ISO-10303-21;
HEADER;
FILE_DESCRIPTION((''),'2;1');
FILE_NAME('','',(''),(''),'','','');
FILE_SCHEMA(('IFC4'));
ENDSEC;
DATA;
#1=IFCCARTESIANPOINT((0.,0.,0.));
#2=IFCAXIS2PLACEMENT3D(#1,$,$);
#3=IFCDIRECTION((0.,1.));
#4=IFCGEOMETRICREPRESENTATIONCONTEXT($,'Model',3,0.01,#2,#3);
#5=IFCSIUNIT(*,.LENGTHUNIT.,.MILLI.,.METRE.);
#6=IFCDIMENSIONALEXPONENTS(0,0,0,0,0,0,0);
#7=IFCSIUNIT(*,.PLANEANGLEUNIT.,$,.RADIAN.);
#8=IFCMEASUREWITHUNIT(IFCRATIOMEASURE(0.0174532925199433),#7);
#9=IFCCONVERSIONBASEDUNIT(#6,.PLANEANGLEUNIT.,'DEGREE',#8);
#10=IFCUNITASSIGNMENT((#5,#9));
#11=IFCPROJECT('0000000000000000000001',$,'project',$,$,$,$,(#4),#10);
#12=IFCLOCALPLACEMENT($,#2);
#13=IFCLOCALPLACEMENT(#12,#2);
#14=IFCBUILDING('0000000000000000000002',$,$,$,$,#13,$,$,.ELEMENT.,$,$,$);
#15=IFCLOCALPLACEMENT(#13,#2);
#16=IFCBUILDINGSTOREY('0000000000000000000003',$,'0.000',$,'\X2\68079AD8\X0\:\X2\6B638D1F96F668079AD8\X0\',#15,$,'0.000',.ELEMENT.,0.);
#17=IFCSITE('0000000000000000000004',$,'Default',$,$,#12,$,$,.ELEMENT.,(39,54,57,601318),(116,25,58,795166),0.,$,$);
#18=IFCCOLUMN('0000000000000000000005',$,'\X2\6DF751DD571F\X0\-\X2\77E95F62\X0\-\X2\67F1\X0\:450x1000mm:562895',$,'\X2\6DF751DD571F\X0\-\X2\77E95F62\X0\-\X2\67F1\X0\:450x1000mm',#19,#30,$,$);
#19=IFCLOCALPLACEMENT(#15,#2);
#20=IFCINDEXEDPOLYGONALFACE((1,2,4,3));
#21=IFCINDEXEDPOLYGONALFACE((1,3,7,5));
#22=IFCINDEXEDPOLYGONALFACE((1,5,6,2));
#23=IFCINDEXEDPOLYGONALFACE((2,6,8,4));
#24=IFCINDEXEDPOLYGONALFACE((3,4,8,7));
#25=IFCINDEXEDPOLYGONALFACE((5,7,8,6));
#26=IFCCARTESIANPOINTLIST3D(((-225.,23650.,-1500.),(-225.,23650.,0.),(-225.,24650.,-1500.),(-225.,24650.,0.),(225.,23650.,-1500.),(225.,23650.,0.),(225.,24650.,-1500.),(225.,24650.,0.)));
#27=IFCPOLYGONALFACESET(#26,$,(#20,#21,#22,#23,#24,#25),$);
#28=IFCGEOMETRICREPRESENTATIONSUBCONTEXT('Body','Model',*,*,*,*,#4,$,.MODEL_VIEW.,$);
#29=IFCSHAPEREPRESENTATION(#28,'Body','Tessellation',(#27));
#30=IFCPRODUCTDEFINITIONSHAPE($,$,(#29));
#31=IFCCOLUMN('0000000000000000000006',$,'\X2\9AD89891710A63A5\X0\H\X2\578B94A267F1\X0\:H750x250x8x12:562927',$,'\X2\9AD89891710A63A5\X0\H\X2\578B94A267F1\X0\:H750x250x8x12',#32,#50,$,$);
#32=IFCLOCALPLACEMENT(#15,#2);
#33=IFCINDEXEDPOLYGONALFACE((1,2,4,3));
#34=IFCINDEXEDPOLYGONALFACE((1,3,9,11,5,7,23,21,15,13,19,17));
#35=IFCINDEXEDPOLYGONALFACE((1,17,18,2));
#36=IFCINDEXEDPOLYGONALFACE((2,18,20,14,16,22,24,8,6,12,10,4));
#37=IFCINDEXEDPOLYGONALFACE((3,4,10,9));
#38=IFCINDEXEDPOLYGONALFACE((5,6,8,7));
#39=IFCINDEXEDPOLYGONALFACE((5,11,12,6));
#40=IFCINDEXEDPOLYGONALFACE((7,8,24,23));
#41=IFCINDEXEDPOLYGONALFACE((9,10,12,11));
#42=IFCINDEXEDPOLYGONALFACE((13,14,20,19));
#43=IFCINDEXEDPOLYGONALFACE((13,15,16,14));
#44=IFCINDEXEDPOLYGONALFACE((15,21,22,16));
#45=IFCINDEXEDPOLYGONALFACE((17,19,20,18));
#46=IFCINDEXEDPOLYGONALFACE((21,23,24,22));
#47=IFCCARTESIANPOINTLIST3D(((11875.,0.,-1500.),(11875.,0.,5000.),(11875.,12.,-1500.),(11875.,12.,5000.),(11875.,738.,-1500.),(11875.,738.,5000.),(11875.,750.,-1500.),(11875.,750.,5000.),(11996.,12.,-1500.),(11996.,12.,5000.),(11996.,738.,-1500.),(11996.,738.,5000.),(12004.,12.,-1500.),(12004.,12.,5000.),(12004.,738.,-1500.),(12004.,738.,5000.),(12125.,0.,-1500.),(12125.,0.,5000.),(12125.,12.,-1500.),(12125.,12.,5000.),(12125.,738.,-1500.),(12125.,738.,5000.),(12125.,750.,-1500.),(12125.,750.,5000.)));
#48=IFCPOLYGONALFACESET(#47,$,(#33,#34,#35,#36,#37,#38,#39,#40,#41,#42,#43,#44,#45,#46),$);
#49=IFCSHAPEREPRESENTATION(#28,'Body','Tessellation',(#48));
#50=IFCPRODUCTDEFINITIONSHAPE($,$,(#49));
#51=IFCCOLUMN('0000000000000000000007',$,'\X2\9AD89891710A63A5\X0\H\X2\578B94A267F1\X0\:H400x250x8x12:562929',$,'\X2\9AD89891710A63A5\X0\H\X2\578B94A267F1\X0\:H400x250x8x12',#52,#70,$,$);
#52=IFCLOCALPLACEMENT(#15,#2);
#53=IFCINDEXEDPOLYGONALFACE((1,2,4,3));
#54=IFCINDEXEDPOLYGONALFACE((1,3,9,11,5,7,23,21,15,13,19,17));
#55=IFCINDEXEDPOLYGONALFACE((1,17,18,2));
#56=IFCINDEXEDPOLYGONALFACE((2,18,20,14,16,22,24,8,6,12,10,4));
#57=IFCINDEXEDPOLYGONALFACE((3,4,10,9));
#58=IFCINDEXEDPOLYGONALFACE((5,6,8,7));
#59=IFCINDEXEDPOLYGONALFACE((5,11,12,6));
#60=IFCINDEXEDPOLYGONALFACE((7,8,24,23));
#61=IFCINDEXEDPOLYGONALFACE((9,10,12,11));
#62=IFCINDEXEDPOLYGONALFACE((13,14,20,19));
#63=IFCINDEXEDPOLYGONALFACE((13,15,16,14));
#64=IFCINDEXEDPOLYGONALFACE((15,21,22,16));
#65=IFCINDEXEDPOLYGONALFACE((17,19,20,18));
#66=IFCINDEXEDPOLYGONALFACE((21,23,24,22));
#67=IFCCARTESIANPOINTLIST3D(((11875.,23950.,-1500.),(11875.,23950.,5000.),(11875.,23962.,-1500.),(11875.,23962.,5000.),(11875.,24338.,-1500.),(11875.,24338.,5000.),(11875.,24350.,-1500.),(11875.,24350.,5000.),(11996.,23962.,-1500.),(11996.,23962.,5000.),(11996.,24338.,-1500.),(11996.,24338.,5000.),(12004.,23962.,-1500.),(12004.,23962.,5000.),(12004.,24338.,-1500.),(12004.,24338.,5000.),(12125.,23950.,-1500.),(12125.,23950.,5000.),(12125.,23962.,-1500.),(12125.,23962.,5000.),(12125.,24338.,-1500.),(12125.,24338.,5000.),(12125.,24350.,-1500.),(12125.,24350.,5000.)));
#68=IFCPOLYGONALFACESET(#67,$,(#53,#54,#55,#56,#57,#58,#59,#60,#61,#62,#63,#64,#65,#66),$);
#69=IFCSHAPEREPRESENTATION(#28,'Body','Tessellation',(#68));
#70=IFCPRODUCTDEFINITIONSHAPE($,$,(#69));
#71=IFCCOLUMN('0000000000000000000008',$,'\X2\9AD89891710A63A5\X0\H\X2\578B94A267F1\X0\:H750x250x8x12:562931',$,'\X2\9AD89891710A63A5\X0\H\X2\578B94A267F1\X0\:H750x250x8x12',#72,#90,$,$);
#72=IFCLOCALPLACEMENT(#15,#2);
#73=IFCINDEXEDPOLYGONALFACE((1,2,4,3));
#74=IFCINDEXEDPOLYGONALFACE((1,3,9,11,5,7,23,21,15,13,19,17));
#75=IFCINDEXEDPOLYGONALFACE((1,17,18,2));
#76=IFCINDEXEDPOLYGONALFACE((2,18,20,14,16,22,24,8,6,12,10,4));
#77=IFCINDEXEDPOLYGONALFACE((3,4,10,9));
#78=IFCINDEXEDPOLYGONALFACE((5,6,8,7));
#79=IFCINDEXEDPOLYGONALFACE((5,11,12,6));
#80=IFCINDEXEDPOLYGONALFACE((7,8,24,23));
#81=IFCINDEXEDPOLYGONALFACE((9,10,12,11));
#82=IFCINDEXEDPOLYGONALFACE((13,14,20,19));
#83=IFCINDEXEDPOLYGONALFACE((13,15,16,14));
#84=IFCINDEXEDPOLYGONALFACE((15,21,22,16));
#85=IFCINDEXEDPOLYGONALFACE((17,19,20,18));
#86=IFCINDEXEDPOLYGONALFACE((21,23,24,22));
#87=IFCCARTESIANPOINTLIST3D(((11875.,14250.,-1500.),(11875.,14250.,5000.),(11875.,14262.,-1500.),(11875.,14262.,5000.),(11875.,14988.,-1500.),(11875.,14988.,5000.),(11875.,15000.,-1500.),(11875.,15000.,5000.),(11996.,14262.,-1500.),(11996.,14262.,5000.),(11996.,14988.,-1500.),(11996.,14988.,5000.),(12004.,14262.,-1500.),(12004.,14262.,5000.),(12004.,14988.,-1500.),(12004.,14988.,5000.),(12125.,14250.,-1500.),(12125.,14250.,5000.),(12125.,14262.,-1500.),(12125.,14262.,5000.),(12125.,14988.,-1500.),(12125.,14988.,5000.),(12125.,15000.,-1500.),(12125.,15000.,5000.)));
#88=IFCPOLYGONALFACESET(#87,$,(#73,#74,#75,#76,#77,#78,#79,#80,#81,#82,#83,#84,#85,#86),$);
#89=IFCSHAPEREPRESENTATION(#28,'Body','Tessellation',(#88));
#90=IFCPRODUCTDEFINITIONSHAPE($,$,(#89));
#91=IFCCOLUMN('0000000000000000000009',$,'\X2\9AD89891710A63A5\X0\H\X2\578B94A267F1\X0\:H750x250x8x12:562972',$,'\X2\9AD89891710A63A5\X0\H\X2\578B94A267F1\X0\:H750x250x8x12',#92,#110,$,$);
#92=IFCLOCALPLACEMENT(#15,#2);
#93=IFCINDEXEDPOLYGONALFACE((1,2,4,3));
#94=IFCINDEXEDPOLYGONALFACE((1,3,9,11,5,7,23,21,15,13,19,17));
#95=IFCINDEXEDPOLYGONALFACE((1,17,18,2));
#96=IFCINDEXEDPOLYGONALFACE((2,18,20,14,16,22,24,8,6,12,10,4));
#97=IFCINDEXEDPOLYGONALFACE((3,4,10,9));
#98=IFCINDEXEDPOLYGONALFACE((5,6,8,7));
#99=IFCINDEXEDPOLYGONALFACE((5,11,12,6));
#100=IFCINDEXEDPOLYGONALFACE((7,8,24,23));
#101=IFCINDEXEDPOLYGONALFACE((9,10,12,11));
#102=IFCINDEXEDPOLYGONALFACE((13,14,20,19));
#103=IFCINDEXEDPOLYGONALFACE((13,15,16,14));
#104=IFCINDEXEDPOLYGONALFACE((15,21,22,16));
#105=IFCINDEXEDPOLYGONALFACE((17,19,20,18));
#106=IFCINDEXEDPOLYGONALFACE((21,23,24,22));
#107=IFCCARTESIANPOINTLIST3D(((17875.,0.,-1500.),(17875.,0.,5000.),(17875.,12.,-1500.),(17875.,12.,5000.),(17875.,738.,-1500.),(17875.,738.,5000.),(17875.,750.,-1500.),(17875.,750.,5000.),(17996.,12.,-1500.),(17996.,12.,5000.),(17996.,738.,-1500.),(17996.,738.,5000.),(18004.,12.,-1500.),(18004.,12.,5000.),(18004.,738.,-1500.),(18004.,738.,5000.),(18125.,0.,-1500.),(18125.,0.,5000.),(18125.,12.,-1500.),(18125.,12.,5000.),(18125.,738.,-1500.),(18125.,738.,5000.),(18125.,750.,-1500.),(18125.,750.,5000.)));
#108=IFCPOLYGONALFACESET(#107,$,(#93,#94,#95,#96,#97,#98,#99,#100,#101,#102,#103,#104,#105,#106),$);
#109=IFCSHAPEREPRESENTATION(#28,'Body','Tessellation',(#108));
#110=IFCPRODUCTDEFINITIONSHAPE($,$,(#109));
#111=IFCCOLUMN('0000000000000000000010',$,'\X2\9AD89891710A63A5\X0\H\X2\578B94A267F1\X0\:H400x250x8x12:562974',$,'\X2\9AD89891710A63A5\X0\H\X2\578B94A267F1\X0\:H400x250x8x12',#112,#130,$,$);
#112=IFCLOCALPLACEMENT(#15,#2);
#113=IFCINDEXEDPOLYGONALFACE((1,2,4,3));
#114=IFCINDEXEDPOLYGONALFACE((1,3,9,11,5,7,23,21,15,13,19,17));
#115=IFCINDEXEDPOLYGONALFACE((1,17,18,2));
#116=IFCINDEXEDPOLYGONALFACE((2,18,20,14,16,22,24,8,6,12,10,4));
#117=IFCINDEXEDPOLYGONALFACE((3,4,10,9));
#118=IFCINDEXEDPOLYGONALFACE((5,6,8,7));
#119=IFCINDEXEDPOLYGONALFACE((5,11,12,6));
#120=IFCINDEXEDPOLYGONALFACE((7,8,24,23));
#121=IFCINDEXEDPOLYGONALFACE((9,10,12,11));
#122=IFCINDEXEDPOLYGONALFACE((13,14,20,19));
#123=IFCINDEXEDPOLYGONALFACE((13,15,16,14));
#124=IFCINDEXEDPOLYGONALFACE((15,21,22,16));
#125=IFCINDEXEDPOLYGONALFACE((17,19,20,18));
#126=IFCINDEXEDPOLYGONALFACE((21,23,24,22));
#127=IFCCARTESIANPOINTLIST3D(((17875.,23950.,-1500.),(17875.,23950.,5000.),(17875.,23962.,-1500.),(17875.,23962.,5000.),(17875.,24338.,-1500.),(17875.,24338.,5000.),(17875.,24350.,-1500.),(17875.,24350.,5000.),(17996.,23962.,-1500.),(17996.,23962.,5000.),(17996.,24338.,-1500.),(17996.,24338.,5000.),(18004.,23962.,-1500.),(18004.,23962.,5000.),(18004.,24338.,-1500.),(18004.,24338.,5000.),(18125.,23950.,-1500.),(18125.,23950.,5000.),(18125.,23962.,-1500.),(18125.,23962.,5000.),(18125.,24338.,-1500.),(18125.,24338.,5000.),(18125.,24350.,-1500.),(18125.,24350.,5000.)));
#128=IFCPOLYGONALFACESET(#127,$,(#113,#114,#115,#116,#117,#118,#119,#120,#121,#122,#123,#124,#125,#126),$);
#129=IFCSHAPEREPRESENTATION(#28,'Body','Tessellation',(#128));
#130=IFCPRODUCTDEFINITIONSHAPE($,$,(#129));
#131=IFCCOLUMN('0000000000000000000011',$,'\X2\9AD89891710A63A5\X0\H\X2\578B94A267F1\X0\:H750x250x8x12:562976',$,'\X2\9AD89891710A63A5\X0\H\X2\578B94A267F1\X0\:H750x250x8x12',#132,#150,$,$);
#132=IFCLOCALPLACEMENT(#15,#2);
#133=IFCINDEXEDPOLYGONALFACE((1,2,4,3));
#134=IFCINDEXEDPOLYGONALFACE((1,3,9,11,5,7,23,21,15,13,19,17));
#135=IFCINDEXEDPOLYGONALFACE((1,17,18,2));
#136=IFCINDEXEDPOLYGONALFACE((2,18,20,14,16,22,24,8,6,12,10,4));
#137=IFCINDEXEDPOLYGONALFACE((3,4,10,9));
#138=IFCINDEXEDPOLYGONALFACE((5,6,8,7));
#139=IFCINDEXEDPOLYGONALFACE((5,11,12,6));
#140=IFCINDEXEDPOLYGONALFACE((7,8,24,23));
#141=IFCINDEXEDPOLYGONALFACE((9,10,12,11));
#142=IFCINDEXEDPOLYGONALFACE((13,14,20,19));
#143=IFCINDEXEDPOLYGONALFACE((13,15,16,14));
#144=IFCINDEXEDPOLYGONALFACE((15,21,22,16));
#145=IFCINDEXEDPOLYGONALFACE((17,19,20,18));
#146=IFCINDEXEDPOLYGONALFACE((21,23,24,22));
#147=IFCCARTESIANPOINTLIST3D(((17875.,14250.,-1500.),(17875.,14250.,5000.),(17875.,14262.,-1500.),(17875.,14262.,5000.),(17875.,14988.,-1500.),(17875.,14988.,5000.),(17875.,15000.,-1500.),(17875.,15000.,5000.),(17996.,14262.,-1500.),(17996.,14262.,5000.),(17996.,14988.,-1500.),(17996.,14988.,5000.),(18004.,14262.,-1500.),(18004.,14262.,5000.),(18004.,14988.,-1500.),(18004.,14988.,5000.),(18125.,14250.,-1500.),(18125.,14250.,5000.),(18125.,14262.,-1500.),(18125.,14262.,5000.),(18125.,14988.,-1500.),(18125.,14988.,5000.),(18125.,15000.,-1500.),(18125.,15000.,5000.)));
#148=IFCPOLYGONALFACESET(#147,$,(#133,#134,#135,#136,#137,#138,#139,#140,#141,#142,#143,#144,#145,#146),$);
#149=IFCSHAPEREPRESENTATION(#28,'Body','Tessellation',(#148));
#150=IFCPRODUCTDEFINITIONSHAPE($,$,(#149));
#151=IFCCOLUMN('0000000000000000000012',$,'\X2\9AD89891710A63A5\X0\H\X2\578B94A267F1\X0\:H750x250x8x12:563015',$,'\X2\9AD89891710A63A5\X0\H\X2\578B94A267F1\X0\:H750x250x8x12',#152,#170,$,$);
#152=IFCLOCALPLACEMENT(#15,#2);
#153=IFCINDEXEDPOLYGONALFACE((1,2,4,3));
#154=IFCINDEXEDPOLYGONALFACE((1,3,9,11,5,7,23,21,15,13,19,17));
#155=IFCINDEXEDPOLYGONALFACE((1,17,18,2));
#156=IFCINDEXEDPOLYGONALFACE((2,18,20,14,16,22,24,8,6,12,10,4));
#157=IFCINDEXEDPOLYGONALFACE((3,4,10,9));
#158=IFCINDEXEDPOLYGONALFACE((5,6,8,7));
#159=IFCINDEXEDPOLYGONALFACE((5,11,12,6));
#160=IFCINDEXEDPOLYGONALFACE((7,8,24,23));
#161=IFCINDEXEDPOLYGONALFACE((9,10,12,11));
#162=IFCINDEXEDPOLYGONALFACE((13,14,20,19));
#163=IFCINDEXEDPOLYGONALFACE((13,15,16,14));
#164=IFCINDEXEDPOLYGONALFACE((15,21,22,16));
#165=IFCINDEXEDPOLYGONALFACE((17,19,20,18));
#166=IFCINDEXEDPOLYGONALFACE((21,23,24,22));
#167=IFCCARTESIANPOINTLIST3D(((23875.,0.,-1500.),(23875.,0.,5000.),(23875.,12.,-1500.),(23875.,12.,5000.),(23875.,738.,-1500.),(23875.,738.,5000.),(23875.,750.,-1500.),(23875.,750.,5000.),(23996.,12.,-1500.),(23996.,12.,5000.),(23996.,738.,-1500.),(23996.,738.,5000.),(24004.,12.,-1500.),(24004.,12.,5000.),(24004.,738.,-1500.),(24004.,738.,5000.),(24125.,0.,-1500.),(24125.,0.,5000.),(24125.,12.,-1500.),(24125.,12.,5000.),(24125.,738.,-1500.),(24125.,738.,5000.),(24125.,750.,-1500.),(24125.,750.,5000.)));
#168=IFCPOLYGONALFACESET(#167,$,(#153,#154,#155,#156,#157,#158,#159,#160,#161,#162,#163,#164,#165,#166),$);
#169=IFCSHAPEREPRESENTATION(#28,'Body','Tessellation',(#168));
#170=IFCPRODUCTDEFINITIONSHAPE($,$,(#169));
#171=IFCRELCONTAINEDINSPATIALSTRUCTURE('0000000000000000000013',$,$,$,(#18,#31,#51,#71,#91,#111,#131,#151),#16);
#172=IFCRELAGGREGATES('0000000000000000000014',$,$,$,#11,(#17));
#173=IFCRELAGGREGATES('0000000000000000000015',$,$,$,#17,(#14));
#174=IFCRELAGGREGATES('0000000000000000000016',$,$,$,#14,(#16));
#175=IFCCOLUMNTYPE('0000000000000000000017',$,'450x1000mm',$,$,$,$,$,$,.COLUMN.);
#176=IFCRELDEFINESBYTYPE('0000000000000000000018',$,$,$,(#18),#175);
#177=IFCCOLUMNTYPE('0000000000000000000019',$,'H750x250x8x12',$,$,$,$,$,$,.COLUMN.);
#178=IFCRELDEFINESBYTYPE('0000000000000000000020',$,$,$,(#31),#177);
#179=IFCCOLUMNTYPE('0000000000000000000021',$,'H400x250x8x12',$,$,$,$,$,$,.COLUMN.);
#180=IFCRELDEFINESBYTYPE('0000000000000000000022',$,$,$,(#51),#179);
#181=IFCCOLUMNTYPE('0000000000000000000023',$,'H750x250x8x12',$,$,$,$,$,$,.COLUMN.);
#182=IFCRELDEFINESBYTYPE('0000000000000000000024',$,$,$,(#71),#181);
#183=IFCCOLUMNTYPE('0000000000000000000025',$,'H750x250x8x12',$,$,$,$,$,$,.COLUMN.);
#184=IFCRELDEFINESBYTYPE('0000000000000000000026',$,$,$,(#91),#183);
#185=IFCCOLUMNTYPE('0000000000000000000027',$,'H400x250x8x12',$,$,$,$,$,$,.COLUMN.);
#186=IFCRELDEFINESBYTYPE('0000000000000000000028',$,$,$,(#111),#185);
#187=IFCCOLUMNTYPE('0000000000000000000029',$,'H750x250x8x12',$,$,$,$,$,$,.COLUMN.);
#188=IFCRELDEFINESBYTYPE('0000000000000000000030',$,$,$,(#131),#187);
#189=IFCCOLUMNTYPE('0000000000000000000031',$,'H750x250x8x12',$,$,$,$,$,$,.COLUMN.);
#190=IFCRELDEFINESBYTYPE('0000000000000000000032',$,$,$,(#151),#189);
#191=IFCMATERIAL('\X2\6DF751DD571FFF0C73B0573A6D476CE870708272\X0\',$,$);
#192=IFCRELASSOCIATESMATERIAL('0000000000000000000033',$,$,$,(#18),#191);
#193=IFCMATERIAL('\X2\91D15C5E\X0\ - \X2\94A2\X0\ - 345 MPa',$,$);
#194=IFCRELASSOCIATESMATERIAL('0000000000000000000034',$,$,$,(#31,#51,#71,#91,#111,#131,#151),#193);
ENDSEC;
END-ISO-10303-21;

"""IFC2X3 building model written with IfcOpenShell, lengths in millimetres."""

from ifc_helpers import new_model, entity, si_unit, converted_unit, direction, frame, origin, origin_2d_with_axis, place, context, subcontext, project, spatial, polyline, rectangle, outline, extrude, source, transform, mapped, material, type_object, type_shapes, element, save


model = new_model("IFC2X3")

# Units and contexts
model_context = context("Model", 3, precision=0.01, world=origin(), true_north=direction((0.0, 1.0)))
body_context = subcontext(model_context, "Body", "Model", "MODEL_VIEW")
ifc_project = project(units=[si_unit("LENGTHUNIT", "METRE", prefix="MILLI"), converted_unit("PLANEANGLEUNIT", "DEGREE", entity("IfcRatioMeasure", 0.0174532925199433), si_unit("PLANEANGLEUNIT", "RADIAN"), dimensions=[0, 0, 0, 0, 0, 0, 0])], contexts=[model_context])

# Site, building, storey
site_placement = place(None, origin())
site = spatial("IfcSite", under=ifc_project, at=site_placement, Name="Default", CompositionType="ELEMENT", RefLatitude=(39, 54, 57, 601318), RefLongitude=(116, 25, 58, 795166), RefElevation=0.0)
building_placement = place(site_placement, origin())
building = spatial("IfcBuilding", under=site, at=building_placement, CompositionType="ELEMENT")
storey_placement = place(building_placement, origin())
storey = spatial("IfcBuildingStorey", under=building, at=storey_placement, Name="0.000", ObjectType="标高:正负零标高", LongName="0.000", CompositionType="ELEMENT", Elevation=0.0)

# Columns
ifc_material_1 = material(Name="混凝土，现场浇注灰色")
column_type_1 = type_object("IfcColumnType", Name="450x1000mm", PredefinedType="COLUMN")
shared_shape_1 = source(origin(), body_context, "Body", "SweptSolid", [
    extrude(rectangle(XDim=1000.0, YDim=450.0, at=origin_2d_with_axis()), frame((0.0, 24150.0, -1500.0), z_axis=(0.0, 0.0, 1.0), x_axis=(0.0, -1.0, 0.0)), (0.0, 0.0, 1.0), 1500.0),
])
type_shapes(column_type_1, [shared_shape_1])
column_1_placement = place(storey_placement, origin())
element("IfcColumn", 1, at=column_1_placement, inside=storey, type_object=column_type_1, material=ifc_material_1, Name="混凝土-矩形-柱:450x1000mm:562895", ObjectType="混凝土-矩形-柱:450x1000mm", context=body_context, shape_type="MappedRepresentation", body=[
    mapped(shared_shape_1, transform((0.0, 0.0, 0.0), scale=1.0)),
])
ifc_material_2 = material(Name="金属 - 钢 - 345 MPa")
column_type_2 = type_object("IfcColumnType", Name="H750x250x8x12", PredefinedType="COLUMN")
shared_shape_2 = source(origin(), body_context, "Body", "SweptSolid", [
    extrude(outline(polyline([(363.0, -125.0), (375.0, -125.0), (375.0, 125.0), (363.0, 125.0), (363.0, 4.0), (-363.0, 4.0), (-363.0, 125.0), (-375.0, 125.0), (-375.0, -125.0), (-363.0, -125.0), (-363.0, -4.0), (363.0, -4.0), (363.0, -125.0)])), frame((12000.0, 375.0, -1500.0), z_axis=(0.0, 0.0, 1.0), x_axis=(0.0, -1.0, 0.0)), (0.0, 0.0, 1.0), 6500.0),
])
type_shapes(column_type_2, [shared_shape_2])
column_2_placement = place(storey_placement, origin())
element("IfcColumn", 2, at=column_2_placement, inside=storey, type_object=column_type_2, material=ifc_material_2, Name="高频焊接H型钢柱:H750x250x8x12:562927", ObjectType="高频焊接H型钢柱:H750x250x8x12", context=body_context, shape_type="MappedRepresentation", body=[
    mapped(shared_shape_2, transform((0.0, 0.0, 0.0), scale=1.0)),
])
column_type_3 = type_object("IfcColumnType", Name="H400x250x8x12", PredefinedType="COLUMN")
shared_shape_3 = source(origin(), body_context, "Body", "SweptSolid", [
    extrude(outline(polyline([(188.0, -125.0), (200.0, -125.0), (200.0, 125.0), (188.0, 125.0), (188.0, 4.0), (-188.0, 4.0), (-188.0, 125.0), (-200.0, 125.0), (-200.0, -125.0), (-188.0, -125.0), (-188.0, -4.0), (188.0, -4.0), (188.0, -125.0)])), frame((12000.0, 24150.0, -1500.0), z_axis=(0.0, 0.0, 1.0), x_axis=(0.0, -1.0, 0.0)), (0.0, 0.0, 1.0), 6500.0),
])
type_shapes(column_type_3, [shared_shape_3])
column_3_placement = place(storey_placement, origin())
element("IfcColumn", 3, at=column_3_placement, inside=storey, type_object=column_type_3, material=ifc_material_2, Name="高频焊接H型钢柱:H400x250x8x12:562929", ObjectType="高频焊接H型钢柱:H400x250x8x12", context=body_context, shape_type="MappedRepresentation", body=[
    mapped(shared_shape_3, transform((0.0, 0.0, 0.0), scale=1.0)),
])
column_type_4 = type_object("IfcColumnType", Name="H750x250x8x12", PredefinedType="COLUMN")
shared_shape_4 = source(origin(), body_context, "Body", "SweptSolid", [
    extrude(outline(polyline([(363.0, -125.0), (375.0, -125.0), (375.0, 125.0), (363.0, 125.0), (363.0, 4.0), (-363.0, 4.0), (-363.0, 125.0), (-375.0, 125.0), (-375.0, -125.0), (-363.0, -125.0), (-363.0, -4.0), (363.0, -4.0), (363.0, -125.0)])), frame((12000.0, 14625.0, -1500.0), z_axis=(0.0, 0.0, 1.0), x_axis=(0.0, -1.0, 0.0)), (0.0, 0.0, 1.0), 6500.0),
])
type_shapes(column_type_4, [shared_shape_4])
column_4_placement = place(storey_placement, origin())
element("IfcColumn", 4, at=column_4_placement, inside=storey, type_object=column_type_4, material=ifc_material_2, Name="高频焊接H型钢柱:H750x250x8x12:562931", ObjectType="高频焊接H型钢柱:H750x250x8x12", context=body_context, shape_type="MappedRepresentation", body=[
    mapped(shared_shape_4, transform((0.0, 0.0, 0.0), scale=1.0)),
])
column_type_5 = type_object("IfcColumnType", Name="H750x250x8x12", PredefinedType="COLUMN")
shared_shape_5 = source(origin(), body_context, "Body", "SweptSolid", [
    extrude(outline(polyline([(363.0, -125.0), (375.0, -125.0), (375.0, 125.0), (363.0, 125.0), (363.0, 4.0), (-363.0, 4.0), (-363.0, 125.0), (-375.0, 125.0), (-375.0, -125.0), (-363.0, -125.0), (-363.0, -4.0), (363.0, -4.0), (363.0, -125.0)])), frame((18000.0, 375.0, -1500.0), z_axis=(0.0, 0.0, 1.0), x_axis=(0.0, -1.0, 0.0)), (0.0, 0.0, 1.0), 6500.0),
])
type_shapes(column_type_5, [shared_shape_5])
column_5_placement = place(storey_placement, origin())
element("IfcColumn", 5, at=column_5_placement, inside=storey, type_object=column_type_5, material=ifc_material_2, Name="高频焊接H型钢柱:H750x250x8x12:562972", ObjectType="高频焊接H型钢柱:H750x250x8x12", context=body_context, shape_type="MappedRepresentation", body=[
    mapped(shared_shape_5, transform((0.0, 0.0, 0.0), scale=1.0)),
])
column_type_6 = type_object("IfcColumnType", Name="H400x250x8x12", PredefinedType="COLUMN")
shared_shape_6 = source(origin(), body_context, "Body", "SweptSolid", [
    extrude(outline(polyline([(188.0, -125.0), (200.0, -125.0), (200.0, 125.0), (188.0, 125.0), (188.0, 4.0), (-188.0, 4.0), (-188.0, 125.0), (-200.0, 125.0), (-200.0, -125.0), (-188.0, -125.0), (-188.0, -4.0), (188.0, -4.0), (188.0, -125.0)])), frame((18000.0, 24150.0, -1500.0), z_axis=(0.0, 0.0, 1.0), x_axis=(0.0, -1.0, 0.0)), (0.0, 0.0, 1.0), 6500.0),
])
type_shapes(column_type_6, [shared_shape_6])
column_6_placement = place(storey_placement, origin())
element("IfcColumn", 6, at=column_6_placement, inside=storey, type_object=column_type_6, material=ifc_material_2, Name="高频焊接H型钢柱:H400x250x8x12:562974", ObjectType="高频焊接H型钢柱:H400x250x8x12", context=body_context, shape_type="MappedRepresentation", body=[
    mapped(shared_shape_6, transform((0.0, 0.0, 0.0), scale=1.0)),
])
column_type_7 = type_object("IfcColumnType", Name="H750x250x8x12", PredefinedType="COLUMN")
shared_shape_7 = source(origin(), body_context, "Body", "SweptSolid", [
    extrude(outline(polyline([(363.0, -125.0), (375.0, -125.0), (375.0, 125.0), (363.0, 125.0), (363.0, 4.0), (-363.0, 4.0), (-363.0, 125.0), (-375.0, 125.0), (-375.0, -125.0), (-363.0, -125.0), (-363.0, -4.0), (363.0, -4.0), (363.0, -125.0)])), frame((18000.0, 14625.0, -1500.0), z_axis=(0.0, 0.0, 1.0), x_axis=(0.0, -1.0, 0.0)), (0.0, 0.0, 1.0), 6500.0),
])
type_shapes(column_type_7, [shared_shape_7])
column_7_placement = place(storey_placement, origin())
element("IfcColumn", 7, at=column_7_placement, inside=storey, type_object=column_type_7, material=ifc_material_2, Name="高频焊接H型钢柱:H750x250x8x12:562976", ObjectType="高频焊接H型钢柱:H750x250x8x12", context=body_context, shape_type="MappedRepresentation", body=[
    mapped(shared_shape_7, transform((0.0, 0.0, 0.0), scale=1.0)),
])
column_type_8 = type_object("IfcColumnType", Name="H750x250x8x12", PredefinedType="COLUMN")
shared_shape_8 = source(origin(), body_context, "Body", "SweptSolid", [
    extrude(outline(polyline([(363.0, -125.0), (375.0, -125.0), (375.0, 125.0), (363.0, 125.0), (363.0, 4.0), (-363.0, 4.0), (-363.0, 125.0), (-375.0, 125.0), (-375.0, -125.0), (-363.0, -125.0), (-363.0, -4.0), (363.0, -4.0), (363.0, -125.0)])), frame((24000.0, 375.0, -1500.0), z_axis=(0.0, 0.0, 1.0), x_axis=(0.0, -1.0, 0.0)), (0.0, 0.0, 1.0), 6500.0),
])
type_shapes(column_type_8, [shared_shape_8])
column_8_placement = place(storey_placement, origin())
element("IfcColumn", 8, at=column_8_placement, inside=storey, type_object=column_type_8, material=ifc_material_2, Name="高频焊接H型钢柱:H750x250x8x12:563015", ObjectType="高频焊接H型钢柱:H750x250x8x12", context=body_context, shape_type="MappedRepresentation", body=[
    mapped(shared_shape_8, transform((0.0, 0.0, 0.0), scale=1.0)),
])

save(model, "model.ifc")
